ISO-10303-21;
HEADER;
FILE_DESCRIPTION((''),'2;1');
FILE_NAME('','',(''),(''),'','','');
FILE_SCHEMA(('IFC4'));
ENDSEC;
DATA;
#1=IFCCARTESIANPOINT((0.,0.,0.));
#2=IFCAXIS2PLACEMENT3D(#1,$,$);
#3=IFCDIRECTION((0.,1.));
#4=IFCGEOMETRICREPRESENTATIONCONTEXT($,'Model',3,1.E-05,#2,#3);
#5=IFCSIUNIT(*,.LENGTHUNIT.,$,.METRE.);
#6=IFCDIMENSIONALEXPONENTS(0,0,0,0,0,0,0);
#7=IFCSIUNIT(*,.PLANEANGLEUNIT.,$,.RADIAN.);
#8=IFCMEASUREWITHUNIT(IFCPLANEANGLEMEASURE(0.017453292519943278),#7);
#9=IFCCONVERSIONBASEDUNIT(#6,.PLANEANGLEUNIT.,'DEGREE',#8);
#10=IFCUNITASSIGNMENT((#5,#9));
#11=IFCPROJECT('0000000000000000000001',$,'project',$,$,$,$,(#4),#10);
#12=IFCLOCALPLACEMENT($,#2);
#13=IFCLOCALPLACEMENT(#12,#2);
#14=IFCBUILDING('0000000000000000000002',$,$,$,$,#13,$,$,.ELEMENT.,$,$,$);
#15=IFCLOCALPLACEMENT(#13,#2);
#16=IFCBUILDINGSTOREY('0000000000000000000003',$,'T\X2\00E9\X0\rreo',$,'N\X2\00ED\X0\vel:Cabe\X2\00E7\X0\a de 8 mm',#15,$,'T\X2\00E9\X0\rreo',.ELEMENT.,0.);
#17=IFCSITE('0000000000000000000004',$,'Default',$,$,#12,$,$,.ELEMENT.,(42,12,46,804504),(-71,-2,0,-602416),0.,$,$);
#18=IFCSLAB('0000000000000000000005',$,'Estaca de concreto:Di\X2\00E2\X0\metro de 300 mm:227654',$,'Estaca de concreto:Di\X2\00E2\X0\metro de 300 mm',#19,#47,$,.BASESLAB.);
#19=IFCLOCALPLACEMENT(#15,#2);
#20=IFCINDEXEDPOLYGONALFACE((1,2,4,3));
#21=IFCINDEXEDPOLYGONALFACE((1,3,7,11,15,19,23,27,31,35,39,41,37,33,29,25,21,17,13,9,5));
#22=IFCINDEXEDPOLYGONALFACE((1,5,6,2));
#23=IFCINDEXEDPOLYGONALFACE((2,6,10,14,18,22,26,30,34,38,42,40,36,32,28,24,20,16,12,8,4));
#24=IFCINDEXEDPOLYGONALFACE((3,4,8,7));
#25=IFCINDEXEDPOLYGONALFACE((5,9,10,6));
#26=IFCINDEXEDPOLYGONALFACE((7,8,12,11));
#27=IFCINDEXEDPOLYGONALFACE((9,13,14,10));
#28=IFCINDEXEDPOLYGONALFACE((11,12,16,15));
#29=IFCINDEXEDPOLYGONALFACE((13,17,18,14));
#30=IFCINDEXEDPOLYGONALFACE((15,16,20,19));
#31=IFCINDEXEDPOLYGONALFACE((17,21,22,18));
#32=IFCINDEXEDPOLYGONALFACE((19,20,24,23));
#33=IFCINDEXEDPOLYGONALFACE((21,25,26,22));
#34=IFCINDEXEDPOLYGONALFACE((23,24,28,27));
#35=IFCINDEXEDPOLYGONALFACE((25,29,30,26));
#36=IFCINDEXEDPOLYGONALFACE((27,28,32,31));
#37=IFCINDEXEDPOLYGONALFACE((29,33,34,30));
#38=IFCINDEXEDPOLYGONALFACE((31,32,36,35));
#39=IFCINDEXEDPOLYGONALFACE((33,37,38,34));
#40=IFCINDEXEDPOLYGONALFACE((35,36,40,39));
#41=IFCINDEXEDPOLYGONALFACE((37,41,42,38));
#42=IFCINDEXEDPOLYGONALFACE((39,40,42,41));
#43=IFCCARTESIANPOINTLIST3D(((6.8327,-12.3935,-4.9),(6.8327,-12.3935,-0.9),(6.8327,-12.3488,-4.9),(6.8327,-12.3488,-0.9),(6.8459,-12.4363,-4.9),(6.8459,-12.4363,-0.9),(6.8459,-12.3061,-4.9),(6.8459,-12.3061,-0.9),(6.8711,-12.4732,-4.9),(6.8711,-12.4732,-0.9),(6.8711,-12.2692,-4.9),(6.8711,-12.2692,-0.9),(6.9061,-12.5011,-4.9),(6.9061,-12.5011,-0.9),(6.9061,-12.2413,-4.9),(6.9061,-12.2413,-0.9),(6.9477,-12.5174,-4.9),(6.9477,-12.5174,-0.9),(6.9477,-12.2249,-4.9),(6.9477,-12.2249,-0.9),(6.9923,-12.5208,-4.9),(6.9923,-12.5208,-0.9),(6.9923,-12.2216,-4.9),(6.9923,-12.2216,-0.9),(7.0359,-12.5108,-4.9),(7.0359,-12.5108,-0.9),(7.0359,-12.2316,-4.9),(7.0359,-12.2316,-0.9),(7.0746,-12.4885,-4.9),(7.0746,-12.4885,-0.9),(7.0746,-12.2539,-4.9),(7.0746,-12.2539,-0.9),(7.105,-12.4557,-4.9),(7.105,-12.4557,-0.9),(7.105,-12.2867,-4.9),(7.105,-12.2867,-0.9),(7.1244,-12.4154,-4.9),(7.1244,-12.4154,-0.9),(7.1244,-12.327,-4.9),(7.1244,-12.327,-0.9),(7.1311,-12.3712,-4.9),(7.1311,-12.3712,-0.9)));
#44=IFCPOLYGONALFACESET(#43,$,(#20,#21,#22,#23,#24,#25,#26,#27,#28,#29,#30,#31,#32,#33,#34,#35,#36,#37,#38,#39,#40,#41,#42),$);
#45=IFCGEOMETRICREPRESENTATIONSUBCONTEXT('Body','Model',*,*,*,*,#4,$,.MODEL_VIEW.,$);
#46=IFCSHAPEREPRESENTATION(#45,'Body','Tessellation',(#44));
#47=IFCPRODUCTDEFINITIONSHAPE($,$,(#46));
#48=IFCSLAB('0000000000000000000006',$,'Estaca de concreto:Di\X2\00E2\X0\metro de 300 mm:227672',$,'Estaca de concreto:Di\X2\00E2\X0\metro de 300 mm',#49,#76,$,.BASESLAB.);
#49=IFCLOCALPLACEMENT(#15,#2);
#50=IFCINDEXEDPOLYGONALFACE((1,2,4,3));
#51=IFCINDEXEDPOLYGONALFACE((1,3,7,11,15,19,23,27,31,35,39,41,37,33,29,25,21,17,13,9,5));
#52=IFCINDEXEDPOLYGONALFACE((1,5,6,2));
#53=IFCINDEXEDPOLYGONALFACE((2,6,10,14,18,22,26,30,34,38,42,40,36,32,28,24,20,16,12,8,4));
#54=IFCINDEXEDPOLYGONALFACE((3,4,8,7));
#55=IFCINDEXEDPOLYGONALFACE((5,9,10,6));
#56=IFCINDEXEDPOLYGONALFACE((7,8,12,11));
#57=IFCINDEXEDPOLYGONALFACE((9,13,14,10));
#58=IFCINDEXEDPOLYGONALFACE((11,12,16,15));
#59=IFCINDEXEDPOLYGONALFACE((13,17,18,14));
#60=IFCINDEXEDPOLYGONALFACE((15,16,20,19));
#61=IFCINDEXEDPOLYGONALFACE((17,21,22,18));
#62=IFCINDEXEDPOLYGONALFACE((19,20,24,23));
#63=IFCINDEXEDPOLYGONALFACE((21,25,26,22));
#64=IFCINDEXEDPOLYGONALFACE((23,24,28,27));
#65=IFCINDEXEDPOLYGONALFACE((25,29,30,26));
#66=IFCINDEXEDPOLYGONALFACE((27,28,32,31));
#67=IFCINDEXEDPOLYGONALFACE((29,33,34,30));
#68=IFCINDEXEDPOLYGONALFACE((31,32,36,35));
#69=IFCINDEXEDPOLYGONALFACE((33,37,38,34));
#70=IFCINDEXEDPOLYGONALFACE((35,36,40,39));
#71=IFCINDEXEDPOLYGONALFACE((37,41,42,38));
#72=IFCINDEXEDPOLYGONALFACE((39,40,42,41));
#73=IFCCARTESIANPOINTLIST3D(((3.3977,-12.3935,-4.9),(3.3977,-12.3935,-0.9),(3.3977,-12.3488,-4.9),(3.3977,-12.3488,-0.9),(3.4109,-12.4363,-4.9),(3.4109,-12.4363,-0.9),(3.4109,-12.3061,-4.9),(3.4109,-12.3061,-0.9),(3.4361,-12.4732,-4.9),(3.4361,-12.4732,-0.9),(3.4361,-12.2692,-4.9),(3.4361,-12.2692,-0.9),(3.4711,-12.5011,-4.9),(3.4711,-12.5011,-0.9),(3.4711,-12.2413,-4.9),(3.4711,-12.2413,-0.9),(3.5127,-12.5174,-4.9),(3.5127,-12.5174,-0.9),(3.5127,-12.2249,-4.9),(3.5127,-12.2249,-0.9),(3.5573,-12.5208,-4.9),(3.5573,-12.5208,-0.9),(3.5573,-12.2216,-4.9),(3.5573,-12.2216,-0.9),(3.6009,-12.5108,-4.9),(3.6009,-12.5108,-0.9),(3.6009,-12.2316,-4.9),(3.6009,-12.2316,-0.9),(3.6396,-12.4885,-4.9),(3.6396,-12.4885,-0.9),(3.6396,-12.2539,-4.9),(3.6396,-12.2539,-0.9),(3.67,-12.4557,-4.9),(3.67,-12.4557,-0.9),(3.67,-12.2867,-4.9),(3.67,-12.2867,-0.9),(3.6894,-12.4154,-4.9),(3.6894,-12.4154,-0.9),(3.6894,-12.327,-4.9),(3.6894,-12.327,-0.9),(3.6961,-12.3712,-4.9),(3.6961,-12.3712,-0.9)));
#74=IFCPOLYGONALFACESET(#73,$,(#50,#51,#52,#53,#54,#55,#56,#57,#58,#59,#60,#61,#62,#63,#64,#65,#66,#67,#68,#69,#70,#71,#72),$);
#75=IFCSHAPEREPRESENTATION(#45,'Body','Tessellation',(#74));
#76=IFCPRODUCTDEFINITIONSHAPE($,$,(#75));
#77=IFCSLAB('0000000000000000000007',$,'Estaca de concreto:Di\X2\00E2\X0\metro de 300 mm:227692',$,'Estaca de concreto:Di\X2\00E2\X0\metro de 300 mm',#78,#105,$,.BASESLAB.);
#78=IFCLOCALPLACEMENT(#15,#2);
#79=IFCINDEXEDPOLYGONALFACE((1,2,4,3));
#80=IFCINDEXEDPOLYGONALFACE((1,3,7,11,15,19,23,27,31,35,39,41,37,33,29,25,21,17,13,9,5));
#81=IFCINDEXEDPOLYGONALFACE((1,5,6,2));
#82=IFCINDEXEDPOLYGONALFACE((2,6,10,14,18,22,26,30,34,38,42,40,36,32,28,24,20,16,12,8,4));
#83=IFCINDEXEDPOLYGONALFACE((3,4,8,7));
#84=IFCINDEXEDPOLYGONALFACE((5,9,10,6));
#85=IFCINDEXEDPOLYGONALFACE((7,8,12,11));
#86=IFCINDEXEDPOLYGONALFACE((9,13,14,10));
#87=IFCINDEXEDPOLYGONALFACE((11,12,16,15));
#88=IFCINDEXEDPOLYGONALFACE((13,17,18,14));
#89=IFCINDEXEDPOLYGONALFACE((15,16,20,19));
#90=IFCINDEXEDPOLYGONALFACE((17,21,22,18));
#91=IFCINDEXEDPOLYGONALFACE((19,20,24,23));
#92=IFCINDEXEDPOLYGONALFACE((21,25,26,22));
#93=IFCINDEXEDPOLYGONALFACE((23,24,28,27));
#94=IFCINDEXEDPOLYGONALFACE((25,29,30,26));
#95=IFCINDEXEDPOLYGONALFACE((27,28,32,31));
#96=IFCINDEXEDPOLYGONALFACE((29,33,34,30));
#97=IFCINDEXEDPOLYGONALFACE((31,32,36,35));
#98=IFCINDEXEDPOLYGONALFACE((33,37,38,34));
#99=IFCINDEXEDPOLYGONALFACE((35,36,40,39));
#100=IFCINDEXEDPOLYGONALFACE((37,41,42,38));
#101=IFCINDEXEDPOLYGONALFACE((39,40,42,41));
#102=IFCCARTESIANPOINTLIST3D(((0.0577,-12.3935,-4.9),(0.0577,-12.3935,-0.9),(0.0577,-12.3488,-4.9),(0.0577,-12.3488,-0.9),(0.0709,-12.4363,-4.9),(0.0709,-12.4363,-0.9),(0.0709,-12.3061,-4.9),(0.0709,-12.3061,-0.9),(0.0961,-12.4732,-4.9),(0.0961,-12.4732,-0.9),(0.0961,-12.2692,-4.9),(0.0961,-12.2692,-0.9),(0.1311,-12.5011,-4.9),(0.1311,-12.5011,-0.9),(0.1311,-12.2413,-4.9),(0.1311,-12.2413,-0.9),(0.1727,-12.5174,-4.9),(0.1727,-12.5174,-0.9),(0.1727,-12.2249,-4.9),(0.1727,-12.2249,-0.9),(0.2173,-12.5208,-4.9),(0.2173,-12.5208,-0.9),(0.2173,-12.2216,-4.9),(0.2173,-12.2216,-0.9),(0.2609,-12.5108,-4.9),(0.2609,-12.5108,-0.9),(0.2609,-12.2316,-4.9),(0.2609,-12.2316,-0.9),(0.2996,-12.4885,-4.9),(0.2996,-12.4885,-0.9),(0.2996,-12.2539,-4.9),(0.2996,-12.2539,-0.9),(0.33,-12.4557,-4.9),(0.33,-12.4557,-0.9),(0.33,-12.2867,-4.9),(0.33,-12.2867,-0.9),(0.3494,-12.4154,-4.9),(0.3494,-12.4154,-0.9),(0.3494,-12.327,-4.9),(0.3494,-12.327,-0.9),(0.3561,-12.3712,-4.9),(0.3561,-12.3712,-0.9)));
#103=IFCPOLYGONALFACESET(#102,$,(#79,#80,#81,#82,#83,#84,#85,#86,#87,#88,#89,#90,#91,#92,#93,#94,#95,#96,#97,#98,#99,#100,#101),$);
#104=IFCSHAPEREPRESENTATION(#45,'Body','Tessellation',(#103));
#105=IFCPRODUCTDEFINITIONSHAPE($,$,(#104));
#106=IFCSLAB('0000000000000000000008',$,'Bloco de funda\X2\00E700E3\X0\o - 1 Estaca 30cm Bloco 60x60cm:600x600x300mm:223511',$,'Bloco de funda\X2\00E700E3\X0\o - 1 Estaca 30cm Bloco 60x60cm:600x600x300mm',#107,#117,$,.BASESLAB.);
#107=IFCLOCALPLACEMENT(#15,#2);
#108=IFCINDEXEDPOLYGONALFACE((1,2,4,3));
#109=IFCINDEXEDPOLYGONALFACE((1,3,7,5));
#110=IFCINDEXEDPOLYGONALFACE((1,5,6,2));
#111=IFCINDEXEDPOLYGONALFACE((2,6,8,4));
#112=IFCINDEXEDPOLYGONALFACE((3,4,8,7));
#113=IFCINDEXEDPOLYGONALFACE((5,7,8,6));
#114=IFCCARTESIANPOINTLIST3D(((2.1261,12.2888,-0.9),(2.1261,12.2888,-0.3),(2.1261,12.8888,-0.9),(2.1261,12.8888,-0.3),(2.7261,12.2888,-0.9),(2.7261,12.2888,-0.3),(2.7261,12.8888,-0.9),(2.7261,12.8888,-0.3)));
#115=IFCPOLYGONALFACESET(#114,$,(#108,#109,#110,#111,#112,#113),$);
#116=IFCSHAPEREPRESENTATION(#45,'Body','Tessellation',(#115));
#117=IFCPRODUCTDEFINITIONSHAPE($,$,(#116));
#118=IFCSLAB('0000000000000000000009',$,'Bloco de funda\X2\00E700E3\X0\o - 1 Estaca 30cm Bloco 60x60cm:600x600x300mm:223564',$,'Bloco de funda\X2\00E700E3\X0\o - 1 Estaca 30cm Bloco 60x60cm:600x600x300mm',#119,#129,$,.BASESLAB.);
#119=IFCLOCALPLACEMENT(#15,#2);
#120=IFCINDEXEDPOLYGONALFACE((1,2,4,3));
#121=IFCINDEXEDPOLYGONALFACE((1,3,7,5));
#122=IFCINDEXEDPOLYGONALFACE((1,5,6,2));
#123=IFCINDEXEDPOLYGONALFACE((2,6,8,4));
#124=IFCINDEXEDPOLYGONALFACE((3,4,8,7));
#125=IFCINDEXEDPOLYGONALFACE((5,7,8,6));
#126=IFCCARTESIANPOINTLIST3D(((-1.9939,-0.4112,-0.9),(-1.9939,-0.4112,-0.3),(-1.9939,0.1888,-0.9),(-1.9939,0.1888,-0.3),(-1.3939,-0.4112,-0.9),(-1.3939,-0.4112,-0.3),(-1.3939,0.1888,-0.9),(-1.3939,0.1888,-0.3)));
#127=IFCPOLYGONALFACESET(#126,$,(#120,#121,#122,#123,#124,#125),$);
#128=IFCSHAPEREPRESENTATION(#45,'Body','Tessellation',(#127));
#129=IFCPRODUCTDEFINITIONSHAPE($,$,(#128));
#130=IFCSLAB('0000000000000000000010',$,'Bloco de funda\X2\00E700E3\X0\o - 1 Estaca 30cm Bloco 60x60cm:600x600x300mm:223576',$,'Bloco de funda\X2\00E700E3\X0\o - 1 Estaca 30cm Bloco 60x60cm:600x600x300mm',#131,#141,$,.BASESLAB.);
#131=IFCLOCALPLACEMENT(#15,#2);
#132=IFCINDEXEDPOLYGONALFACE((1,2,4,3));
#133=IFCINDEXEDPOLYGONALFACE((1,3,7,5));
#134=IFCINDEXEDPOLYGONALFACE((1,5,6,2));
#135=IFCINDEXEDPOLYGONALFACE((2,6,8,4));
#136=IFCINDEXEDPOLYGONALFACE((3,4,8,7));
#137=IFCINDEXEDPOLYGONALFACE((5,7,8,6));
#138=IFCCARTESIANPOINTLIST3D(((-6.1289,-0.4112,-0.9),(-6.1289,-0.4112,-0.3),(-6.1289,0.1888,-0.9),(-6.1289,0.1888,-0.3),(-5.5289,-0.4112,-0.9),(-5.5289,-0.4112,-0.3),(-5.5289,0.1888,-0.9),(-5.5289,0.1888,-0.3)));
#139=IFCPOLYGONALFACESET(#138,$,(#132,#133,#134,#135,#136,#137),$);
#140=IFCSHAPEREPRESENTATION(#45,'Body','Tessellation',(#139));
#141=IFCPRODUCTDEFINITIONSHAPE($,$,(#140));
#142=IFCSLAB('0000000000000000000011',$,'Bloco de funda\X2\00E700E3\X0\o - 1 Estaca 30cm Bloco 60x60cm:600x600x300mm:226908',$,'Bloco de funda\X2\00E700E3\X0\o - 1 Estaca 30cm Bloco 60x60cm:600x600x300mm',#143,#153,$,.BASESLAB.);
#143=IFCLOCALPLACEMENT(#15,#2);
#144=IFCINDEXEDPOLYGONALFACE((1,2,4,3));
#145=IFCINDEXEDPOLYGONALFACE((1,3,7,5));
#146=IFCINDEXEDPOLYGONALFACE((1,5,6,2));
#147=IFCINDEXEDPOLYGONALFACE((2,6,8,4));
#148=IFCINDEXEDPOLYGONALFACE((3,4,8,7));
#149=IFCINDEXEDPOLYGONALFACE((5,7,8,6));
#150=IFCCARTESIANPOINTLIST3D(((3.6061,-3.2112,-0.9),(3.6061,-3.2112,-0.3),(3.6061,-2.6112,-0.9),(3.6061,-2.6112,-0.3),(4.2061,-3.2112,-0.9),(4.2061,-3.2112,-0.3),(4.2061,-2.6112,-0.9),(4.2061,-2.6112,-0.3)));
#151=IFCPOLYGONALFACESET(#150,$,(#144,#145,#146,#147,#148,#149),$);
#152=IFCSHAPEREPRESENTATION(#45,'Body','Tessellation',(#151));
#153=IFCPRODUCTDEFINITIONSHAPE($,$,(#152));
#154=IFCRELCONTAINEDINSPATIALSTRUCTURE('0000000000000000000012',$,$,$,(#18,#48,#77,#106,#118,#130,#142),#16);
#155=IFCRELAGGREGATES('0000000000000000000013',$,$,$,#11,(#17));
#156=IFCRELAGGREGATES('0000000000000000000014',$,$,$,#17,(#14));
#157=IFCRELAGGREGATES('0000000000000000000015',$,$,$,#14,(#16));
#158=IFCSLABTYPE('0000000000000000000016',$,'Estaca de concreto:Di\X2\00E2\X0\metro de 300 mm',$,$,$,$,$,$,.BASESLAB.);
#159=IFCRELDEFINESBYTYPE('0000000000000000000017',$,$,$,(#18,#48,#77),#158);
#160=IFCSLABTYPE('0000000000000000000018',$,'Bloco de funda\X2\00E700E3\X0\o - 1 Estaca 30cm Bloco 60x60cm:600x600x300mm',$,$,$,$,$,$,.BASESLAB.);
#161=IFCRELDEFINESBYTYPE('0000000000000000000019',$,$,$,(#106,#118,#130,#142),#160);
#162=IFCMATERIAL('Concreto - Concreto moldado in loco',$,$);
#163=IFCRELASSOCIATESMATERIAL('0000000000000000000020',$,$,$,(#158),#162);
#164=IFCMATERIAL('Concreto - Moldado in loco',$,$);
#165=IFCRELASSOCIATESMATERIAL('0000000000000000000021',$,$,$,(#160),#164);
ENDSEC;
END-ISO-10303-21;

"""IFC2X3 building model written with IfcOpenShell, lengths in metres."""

from ifc_helpers import new_model, entity, si_unit, converted_unit, direction, frame, frame_2d, origin, origin_2d_with_axis, place, context, subcontext, project, spatial, rectangle, circle, extrude, material, type_object, element, save


model = new_model("IFC2X3")

# Units and contexts
model_context = context("Model", 3, precision=1e-05, world=origin(), true_north=direction((0.0, 1.0)))
body_context = subcontext(model_context, "Body", "Model", "MODEL_VIEW")
ifc_project = project(units=[si_unit("LENGTHUNIT", "METRE"), converted_unit("PLANEANGLEUNIT", "DEGREE", entity("IfcPlaneAngleMeasure", 0.017453292519943278), si_unit("PLANEANGLEUNIT", "RADIAN"), dimensions=[0, 0, 0, 0, 0, 0, 0])], contexts=[model_context])

# Site, building, storey
site_placement = place(None, origin())
site = spatial("IfcSite", under=ifc_project, at=site_placement, Name="Default", CompositionType="ELEMENT", RefLatitude=(42, 12, 46, 804504), RefLongitude=(-71, -2, 0, -602416), RefElevation=0.0)
building_placement = place(site_placement, origin())
building = spatial("IfcBuilding", under=site, at=building_placement, CompositionType="ELEMENT")
storey_placement = place(building_placement, origin())
storey = spatial("IfcBuildingStorey", under=building, at=storey_placement, Name="Térreo", ObjectType="Nível:Cabeça de 8 mm", LongName="Térreo", CompositionType="ELEMENT", Elevation=0.0)

# Slabs
ifc_material_1 = material(Name="Concreto - Moldado in loco")
ifc_material_2 = material(Name="Concreto - Concreto moldado in loco")
slab_type_1 = type_object("IfcSlabType", Name="Estaca de concreto:Diâmetro de 300 mm", PredefinedType="BASESLAB", material=ifc_material_2)
slab_1_placement = place(storey_placement, origin())
element("IfcSlab", 1, at=slab_1_placement, inside=storey, type_object=slab_type_1, Name="Estaca de concreto:Diâmetro de 300 mm:227654", ObjectType="Estaca de concreto:Diâmetro de 300 mm", PredefinedType="BASESLAB", context=body_context, shape_type="SweptSolid", body=[
    extrude(circle(Radius=0.15, at=origin_2d_with_axis()), frame((6.9811, -12.3712, -4.9)), (0.0, 0.0, 1.0), 4.0),
])
slab_2_placement = place(storey_placement, origin())
element("IfcSlab", 2, at=slab_2_placement, inside=storey, type_object=slab_type_1, Name="Estaca de concreto:Diâmetro de 300 mm:227672", ObjectType="Estaca de concreto:Diâmetro de 300 mm", PredefinedType="BASESLAB", context=body_context, shape_type="SweptSolid", body=[
    extrude(circle(Radius=0.15, at=origin_2d_with_axis()), frame((3.5461, -12.3712, -4.9)), (0.0, 0.0, 1.0), 4.0),
])
slab_3_placement = place(storey_placement, origin())
element("IfcSlab", 3, at=slab_3_placement, inside=storey, type_object=slab_type_1, Name="Estaca de concreto:Diâmetro de 300 mm:227692", ObjectType="Estaca de concreto:Diâmetro de 300 mm", PredefinedType="BASESLAB", context=body_context, shape_type="SweptSolid", body=[
    extrude(circle(Radius=0.15, at=frame_2d((0.0, 0.0), x_axis=(1.0, 0.0))), frame((0.2061, -12.3712, -4.9)), (0.0, 0.0, 1.0), 4.0),
])
slab_type_2 = type_object("IfcSlabType", Name="Bloco de fundação - 1 Estaca 30cm Bloco 60x60cm:600x600x300mm", PredefinedType="BASESLAB", material=ifc_material_1)
slab_4_placement = place(storey_placement, origin())
element("IfcSlab", 4, at=slab_4_placement, inside=storey, type_object=slab_type_2, Name="Bloco de fundação - 1 Estaca 30cm Bloco 60x60cm:600x600x300mm:223511", ObjectType="Bloco de fundação - 1 Estaca 30cm Bloco 60x60cm:600x600x300mm", PredefinedType="BASESLAB", context=body_context, shape_type="SweptSolid", body=[
    extrude(rectangle(XDim=0.6, YDim=0.6, at=frame_2d((0.0, 0.0), x_axis=(1.0, 0.0))), frame((2.4261, 12.5888, -0.9), z_axis=(0.0, 0.0, 1.0), x_axis=(-1.0, 0.0, 0.0)), (0.0, 0.0, 1.0), 0.6),
])
slab_5_placement = place(storey_placement, origin())
element("IfcSlab", 5, at=slab_5_placement, inside=storey, type_object=slab_type_2, Name="Bloco de fundação - 1 Estaca 30cm Bloco 60x60cm:600x600x300mm:223564", ObjectType="Bloco de fundação - 1 Estaca 30cm Bloco 60x60cm:600x600x300mm", PredefinedType="BASESLAB", context=body_context, shape_type="SweptSolid", body=[
    extrude(rectangle(XDim=0.6, YDim=0.6, at=frame_2d((0.0, 0.0), x_axis=(1.0, 0.0))), frame((-1.6939, -0.1112, -0.9), z_axis=(0.0, 0.0, 1.0), x_axis=(-1.0, 0.0, 0.0)), (0.0, 0.0, 1.0), 0.6),
])
slab_6_placement = place(storey_placement, origin())
element("IfcSlab", 6, at=slab_6_placement, inside=storey, type_object=slab_type_2, Name="Bloco de fundação - 1 Estaca 30cm Bloco 60x60cm:600x600x300mm:223576", ObjectType="Bloco de fundação - 1 Estaca 30cm Bloco 60x60cm:600x600x300mm", PredefinedType="BASESLAB", context=body_context, shape_type="SweptSolid", body=[
    extrude(rectangle(XDim=0.6, YDim=0.6, at=origin_2d_with_axis()), frame((-5.8289, -0.1112, -0.9), z_axis=(0.0, 0.0, 1.0), x_axis=(-1.0, 0.0, 0.0)), (0.0, 0.0, 1.0), 0.6),
])
slab_7_placement = place(storey_placement, origin())
element("IfcSlab", 7, at=slab_7_placement, inside=storey, type_object=slab_type_2, Name="Bloco de fundação - 1 Estaca 30cm Bloco 60x60cm:600x600x300mm:226908", ObjectType="Bloco de fundação - 1 Estaca 30cm Bloco 60x60cm:600x600x300mm", PredefinedType="BASESLAB", context=body_context, shape_type="SweptSolid", body=[
    extrude(rectangle(XDim=0.6, YDim=0.6, at=origin_2d_with_axis()), frame((3.9061, -2.9112, -0.9), z_axis=(0.0, 0.0, 1.0), x_axis=(-1.0, 0.0, 0.0)), (0.0, 0.0, 1.0), 0.6),
])

save(model, "model.ifc")
